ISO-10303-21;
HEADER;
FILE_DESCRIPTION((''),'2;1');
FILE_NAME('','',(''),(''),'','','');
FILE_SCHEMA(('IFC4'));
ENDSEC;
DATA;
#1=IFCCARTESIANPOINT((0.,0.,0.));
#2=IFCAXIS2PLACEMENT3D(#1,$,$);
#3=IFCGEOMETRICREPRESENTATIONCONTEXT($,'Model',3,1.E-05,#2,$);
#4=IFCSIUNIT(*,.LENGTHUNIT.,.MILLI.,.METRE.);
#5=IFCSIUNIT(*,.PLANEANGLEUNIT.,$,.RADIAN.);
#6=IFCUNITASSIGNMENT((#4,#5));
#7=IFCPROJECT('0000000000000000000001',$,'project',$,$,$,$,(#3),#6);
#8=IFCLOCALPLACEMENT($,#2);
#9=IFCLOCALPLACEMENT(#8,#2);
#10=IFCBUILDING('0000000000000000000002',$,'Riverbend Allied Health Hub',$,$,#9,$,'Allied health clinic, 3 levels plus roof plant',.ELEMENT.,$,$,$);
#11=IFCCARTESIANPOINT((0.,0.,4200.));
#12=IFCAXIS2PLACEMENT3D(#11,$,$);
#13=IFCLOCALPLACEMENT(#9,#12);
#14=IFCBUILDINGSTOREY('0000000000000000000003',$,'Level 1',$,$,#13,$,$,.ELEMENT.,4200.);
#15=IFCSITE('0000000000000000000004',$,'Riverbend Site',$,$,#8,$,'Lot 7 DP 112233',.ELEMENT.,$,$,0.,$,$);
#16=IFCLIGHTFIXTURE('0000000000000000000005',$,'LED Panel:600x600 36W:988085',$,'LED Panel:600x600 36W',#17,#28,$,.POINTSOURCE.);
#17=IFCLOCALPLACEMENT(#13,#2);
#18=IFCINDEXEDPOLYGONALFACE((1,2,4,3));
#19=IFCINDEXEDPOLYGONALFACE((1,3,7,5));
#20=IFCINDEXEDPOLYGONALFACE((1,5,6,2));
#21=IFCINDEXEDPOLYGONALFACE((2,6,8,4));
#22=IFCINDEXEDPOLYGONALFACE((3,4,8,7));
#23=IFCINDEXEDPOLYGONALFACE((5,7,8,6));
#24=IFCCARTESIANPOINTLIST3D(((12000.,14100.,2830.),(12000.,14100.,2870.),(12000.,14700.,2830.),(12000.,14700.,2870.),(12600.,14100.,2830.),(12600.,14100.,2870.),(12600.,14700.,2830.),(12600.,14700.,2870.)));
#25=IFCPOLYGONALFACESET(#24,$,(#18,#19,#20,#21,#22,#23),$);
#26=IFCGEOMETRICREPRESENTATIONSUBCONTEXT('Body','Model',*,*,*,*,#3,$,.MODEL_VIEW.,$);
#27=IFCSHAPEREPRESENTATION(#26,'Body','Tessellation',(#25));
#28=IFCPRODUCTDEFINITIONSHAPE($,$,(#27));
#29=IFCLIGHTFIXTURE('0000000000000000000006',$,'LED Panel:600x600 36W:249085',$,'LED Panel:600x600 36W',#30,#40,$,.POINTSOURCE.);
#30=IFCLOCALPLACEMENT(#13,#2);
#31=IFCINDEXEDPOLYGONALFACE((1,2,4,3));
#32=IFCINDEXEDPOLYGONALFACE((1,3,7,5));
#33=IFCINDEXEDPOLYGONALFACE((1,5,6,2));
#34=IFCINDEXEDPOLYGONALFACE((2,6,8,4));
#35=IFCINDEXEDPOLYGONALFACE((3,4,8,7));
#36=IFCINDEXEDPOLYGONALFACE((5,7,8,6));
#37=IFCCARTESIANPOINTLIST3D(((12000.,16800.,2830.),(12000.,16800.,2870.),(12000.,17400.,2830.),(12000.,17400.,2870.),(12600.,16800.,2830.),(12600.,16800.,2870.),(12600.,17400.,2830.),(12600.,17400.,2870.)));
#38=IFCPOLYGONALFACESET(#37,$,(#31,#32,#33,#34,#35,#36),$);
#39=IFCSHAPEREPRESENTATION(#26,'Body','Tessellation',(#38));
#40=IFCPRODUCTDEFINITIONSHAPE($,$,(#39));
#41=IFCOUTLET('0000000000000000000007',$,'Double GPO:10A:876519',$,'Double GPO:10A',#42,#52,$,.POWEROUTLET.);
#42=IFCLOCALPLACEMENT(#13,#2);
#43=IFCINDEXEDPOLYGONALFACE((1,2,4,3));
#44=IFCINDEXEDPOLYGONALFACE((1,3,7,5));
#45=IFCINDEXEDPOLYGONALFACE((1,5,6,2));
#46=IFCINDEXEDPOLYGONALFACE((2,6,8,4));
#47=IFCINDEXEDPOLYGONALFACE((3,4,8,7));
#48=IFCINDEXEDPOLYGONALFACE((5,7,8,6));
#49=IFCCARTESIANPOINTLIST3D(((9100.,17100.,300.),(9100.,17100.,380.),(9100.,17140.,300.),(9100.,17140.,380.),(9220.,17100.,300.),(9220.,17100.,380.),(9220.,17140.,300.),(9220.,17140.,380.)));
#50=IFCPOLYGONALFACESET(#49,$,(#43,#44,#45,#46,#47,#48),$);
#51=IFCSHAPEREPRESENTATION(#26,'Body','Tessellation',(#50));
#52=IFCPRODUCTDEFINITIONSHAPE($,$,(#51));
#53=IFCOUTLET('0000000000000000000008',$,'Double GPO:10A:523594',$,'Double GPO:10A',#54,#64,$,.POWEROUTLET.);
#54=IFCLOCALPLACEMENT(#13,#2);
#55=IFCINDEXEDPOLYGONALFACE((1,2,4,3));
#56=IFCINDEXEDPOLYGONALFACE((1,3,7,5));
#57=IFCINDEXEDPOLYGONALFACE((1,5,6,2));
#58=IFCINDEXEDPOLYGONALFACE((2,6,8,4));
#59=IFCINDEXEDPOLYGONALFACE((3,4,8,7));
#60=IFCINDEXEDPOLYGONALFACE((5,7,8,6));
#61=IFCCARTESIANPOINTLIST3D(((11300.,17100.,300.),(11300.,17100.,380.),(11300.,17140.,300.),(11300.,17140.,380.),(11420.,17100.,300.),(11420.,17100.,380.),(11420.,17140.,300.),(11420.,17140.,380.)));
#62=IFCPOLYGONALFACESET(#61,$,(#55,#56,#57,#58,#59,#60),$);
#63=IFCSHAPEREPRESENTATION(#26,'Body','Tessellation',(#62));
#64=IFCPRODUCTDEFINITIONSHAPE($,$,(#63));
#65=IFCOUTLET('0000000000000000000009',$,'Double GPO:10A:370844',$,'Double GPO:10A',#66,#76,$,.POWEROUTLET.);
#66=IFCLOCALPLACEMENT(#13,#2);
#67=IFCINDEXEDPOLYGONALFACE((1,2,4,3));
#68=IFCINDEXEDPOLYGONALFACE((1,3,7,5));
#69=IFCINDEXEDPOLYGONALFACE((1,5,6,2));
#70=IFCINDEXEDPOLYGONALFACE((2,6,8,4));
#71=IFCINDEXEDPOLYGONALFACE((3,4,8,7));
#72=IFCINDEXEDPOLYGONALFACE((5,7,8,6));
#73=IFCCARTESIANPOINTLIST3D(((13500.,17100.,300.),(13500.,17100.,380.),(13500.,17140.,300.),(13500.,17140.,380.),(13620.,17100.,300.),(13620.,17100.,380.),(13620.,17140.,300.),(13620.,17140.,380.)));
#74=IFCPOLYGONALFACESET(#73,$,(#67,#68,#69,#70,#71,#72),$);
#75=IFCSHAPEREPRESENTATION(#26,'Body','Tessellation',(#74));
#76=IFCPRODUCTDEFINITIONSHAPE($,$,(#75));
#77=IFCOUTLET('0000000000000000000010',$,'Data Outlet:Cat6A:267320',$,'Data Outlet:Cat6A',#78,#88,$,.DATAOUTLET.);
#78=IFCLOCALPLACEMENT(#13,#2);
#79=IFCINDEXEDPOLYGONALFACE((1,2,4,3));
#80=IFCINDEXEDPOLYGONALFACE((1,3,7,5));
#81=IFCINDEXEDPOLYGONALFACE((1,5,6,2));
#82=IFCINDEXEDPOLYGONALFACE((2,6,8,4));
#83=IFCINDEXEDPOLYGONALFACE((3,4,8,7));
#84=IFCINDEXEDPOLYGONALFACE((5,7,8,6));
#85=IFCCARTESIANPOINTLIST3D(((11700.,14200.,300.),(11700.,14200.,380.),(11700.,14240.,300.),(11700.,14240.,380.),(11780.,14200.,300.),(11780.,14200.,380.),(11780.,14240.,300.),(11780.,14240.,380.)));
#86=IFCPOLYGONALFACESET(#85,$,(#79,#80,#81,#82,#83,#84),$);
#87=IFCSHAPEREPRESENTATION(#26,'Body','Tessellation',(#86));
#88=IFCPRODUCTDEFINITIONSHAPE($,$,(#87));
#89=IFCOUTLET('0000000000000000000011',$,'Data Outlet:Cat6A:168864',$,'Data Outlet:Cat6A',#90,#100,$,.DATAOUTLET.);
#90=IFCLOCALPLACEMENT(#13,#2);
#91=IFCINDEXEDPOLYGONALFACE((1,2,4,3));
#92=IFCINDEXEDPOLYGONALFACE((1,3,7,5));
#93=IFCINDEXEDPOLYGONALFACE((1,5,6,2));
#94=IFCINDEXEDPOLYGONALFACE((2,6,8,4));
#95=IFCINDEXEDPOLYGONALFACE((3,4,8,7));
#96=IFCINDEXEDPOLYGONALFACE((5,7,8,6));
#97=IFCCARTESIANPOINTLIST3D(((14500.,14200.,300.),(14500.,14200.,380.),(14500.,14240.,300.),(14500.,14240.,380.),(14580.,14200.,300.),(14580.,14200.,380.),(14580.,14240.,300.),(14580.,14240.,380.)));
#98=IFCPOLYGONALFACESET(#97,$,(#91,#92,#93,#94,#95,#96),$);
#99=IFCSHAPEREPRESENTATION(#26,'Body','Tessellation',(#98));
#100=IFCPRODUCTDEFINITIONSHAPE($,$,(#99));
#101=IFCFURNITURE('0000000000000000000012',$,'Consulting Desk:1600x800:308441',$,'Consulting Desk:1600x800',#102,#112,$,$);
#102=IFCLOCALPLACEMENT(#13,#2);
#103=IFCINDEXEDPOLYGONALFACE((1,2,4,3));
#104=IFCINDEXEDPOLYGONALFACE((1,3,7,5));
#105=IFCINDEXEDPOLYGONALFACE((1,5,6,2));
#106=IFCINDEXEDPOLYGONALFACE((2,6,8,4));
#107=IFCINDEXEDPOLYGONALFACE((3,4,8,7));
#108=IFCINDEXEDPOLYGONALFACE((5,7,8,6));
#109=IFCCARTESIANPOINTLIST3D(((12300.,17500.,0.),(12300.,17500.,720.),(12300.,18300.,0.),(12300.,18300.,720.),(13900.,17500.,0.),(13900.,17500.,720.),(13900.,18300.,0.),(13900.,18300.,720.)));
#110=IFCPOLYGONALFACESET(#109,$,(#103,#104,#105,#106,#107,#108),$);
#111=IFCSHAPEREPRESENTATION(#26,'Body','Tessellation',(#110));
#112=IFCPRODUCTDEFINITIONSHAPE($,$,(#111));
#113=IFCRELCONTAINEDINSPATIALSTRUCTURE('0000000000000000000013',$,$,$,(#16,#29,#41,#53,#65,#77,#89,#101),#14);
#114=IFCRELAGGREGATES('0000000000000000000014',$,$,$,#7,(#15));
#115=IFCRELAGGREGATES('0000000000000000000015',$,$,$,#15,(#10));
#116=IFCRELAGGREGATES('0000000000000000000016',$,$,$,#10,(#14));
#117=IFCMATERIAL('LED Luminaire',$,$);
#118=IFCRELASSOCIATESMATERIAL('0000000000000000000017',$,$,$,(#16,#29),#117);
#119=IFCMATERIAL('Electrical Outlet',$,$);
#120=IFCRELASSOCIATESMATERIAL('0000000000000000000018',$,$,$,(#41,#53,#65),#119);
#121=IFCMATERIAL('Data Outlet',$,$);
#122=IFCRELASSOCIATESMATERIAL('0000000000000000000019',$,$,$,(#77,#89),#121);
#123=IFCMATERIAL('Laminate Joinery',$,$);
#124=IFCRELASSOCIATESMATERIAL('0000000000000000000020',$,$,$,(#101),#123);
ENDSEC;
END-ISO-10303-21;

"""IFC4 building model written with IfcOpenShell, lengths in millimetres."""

from ifc_helpers import new_model, si_unit, frame, frame_2d, origin, place, context, subcontext, project, spatial, rectangle, extrude, material, element, save


model = new_model("IFC4")

# Units and contexts
model_context = context("Model", 3, precision=1e-05, world=origin())
body_context = subcontext(model_context, "Body", "Model", "MODEL_VIEW")
ifc_project = project(units=[si_unit("LENGTHUNIT", "METRE", prefix="MILLI"), si_unit("PLANEANGLEUNIT", "RADIAN")], contexts=[model_context])

# Site, building, storey
site_placement = place(None, origin())
site = spatial("IfcSite", under=ifc_project, at=site_placement, Name="Riverbend Site", LongName="Lot 7 DP 112233", CompositionType="ELEMENT", RefElevation=0.0)
building_placement = place(site_placement, origin())
building = spatial("IfcBuilding", under=site, at=building_placement, Name="Riverbend Allied Health Hub", LongName="Allied health clinic, 3 levels plus roof plant", CompositionType="ELEMENT")
storey_placement = place(building_placement, frame((0.0, 0.0, 4200.0)))
storey = spatial("IfcBuildingStorey", under=building, at=storey_placement, Name="Level 1", CompositionType="ELEMENT", Elevation=4200.0)

# Light fixtures
ifc_material_1 = material(Name="LED Luminaire")
for number, where, name in (
    (1, (12000.0, 14100.0, 2830.0), "LED Panel:600x600 36W:988085"),
    (2, (12000.0, 16800.0, 2830.0), "LED Panel:600x600 36W:249085"),
):
    element("IfcLightFixture", number, at=place(storey_placement, frame(where)), inside=storey, material=ifc_material_1, Name=name, ObjectType="LED Panel:600x600 36W", PredefinedType="POINTSOURCE", context=body_context, shape_type="SweptSolid", body=[
        extrude(rectangle(XDim=600.0, YDim=600.0, at=frame_2d((300.0, 300.0))), origin(), (0.0, 0.0, 1.0), 40.0),
    ])

# Outlets
ifc_material_2 = material(Name="Electrical Outlet")
for number, where, name in (
    (3, (9100.0, 17100.0, 300.0), "Double GPO:10A:876519"),
    (4, (11300.0, 17100.0, 300.0), "Double GPO:10A:523594"),
    (5, (13500.0, 17100.0, 300.0), "Double GPO:10A:370844"),
):
    element("IfcOutlet", number, at=place(storey_placement, frame(where)), inside=storey, material=ifc_material_2, Name=name, ObjectType="Double GPO:10A", PredefinedType="POWEROUTLET", context=body_context, shape_type="SweptSolid", body=[
        extrude(rectangle(XDim=120.0, YDim=40.0, at=frame_2d((60.0, 20.0))), origin(), (0.0, 0.0, 1.0), 80.0),
    ])
ifc_material_3 = material(Name="Data Outlet")
for number, where, name in (
    (6, (11700.0, 14200.0, 300.0), "Data Outlet:Cat6A:267320"),
    (7, (14500.0, 14200.0, 300.0), "Data Outlet:Cat6A:168864"),
):
    element("IfcOutlet", number, at=place(storey_placement, frame(where)), inside=storey, material=ifc_material_3, Name=name, ObjectType="Data Outlet:Cat6A", PredefinedType="DATAOUTLET", context=body_context, shape_type="SweptSolid", body=[
        extrude(rectangle(XDim=80.0, YDim=40.0, at=frame_2d((40.0, 20.0))), origin(), (0.0, 0.0, 1.0), 80.0),
    ])

# Furniture
ifc_material_4 = material(Name="Laminate Joinery")
furniture_placement = place(storey_placement, frame((12300.0, 17500.0, 0.0)))
element("IfcFurniture", 8, at=furniture_placement, inside=storey, material=ifc_material_4, Name="Consulting Desk:1600x800:308441", ObjectType="Consulting Desk:1600x800", context=body_context, shape_type="SweptSolid", body=[
    extrude(rectangle(XDim=1600.0, YDim=800.0, at=frame_2d((800.0, 400.0))), origin(), (0.0, 0.0, 1.0), 720.0),
])

save(model, "model.ifc")
